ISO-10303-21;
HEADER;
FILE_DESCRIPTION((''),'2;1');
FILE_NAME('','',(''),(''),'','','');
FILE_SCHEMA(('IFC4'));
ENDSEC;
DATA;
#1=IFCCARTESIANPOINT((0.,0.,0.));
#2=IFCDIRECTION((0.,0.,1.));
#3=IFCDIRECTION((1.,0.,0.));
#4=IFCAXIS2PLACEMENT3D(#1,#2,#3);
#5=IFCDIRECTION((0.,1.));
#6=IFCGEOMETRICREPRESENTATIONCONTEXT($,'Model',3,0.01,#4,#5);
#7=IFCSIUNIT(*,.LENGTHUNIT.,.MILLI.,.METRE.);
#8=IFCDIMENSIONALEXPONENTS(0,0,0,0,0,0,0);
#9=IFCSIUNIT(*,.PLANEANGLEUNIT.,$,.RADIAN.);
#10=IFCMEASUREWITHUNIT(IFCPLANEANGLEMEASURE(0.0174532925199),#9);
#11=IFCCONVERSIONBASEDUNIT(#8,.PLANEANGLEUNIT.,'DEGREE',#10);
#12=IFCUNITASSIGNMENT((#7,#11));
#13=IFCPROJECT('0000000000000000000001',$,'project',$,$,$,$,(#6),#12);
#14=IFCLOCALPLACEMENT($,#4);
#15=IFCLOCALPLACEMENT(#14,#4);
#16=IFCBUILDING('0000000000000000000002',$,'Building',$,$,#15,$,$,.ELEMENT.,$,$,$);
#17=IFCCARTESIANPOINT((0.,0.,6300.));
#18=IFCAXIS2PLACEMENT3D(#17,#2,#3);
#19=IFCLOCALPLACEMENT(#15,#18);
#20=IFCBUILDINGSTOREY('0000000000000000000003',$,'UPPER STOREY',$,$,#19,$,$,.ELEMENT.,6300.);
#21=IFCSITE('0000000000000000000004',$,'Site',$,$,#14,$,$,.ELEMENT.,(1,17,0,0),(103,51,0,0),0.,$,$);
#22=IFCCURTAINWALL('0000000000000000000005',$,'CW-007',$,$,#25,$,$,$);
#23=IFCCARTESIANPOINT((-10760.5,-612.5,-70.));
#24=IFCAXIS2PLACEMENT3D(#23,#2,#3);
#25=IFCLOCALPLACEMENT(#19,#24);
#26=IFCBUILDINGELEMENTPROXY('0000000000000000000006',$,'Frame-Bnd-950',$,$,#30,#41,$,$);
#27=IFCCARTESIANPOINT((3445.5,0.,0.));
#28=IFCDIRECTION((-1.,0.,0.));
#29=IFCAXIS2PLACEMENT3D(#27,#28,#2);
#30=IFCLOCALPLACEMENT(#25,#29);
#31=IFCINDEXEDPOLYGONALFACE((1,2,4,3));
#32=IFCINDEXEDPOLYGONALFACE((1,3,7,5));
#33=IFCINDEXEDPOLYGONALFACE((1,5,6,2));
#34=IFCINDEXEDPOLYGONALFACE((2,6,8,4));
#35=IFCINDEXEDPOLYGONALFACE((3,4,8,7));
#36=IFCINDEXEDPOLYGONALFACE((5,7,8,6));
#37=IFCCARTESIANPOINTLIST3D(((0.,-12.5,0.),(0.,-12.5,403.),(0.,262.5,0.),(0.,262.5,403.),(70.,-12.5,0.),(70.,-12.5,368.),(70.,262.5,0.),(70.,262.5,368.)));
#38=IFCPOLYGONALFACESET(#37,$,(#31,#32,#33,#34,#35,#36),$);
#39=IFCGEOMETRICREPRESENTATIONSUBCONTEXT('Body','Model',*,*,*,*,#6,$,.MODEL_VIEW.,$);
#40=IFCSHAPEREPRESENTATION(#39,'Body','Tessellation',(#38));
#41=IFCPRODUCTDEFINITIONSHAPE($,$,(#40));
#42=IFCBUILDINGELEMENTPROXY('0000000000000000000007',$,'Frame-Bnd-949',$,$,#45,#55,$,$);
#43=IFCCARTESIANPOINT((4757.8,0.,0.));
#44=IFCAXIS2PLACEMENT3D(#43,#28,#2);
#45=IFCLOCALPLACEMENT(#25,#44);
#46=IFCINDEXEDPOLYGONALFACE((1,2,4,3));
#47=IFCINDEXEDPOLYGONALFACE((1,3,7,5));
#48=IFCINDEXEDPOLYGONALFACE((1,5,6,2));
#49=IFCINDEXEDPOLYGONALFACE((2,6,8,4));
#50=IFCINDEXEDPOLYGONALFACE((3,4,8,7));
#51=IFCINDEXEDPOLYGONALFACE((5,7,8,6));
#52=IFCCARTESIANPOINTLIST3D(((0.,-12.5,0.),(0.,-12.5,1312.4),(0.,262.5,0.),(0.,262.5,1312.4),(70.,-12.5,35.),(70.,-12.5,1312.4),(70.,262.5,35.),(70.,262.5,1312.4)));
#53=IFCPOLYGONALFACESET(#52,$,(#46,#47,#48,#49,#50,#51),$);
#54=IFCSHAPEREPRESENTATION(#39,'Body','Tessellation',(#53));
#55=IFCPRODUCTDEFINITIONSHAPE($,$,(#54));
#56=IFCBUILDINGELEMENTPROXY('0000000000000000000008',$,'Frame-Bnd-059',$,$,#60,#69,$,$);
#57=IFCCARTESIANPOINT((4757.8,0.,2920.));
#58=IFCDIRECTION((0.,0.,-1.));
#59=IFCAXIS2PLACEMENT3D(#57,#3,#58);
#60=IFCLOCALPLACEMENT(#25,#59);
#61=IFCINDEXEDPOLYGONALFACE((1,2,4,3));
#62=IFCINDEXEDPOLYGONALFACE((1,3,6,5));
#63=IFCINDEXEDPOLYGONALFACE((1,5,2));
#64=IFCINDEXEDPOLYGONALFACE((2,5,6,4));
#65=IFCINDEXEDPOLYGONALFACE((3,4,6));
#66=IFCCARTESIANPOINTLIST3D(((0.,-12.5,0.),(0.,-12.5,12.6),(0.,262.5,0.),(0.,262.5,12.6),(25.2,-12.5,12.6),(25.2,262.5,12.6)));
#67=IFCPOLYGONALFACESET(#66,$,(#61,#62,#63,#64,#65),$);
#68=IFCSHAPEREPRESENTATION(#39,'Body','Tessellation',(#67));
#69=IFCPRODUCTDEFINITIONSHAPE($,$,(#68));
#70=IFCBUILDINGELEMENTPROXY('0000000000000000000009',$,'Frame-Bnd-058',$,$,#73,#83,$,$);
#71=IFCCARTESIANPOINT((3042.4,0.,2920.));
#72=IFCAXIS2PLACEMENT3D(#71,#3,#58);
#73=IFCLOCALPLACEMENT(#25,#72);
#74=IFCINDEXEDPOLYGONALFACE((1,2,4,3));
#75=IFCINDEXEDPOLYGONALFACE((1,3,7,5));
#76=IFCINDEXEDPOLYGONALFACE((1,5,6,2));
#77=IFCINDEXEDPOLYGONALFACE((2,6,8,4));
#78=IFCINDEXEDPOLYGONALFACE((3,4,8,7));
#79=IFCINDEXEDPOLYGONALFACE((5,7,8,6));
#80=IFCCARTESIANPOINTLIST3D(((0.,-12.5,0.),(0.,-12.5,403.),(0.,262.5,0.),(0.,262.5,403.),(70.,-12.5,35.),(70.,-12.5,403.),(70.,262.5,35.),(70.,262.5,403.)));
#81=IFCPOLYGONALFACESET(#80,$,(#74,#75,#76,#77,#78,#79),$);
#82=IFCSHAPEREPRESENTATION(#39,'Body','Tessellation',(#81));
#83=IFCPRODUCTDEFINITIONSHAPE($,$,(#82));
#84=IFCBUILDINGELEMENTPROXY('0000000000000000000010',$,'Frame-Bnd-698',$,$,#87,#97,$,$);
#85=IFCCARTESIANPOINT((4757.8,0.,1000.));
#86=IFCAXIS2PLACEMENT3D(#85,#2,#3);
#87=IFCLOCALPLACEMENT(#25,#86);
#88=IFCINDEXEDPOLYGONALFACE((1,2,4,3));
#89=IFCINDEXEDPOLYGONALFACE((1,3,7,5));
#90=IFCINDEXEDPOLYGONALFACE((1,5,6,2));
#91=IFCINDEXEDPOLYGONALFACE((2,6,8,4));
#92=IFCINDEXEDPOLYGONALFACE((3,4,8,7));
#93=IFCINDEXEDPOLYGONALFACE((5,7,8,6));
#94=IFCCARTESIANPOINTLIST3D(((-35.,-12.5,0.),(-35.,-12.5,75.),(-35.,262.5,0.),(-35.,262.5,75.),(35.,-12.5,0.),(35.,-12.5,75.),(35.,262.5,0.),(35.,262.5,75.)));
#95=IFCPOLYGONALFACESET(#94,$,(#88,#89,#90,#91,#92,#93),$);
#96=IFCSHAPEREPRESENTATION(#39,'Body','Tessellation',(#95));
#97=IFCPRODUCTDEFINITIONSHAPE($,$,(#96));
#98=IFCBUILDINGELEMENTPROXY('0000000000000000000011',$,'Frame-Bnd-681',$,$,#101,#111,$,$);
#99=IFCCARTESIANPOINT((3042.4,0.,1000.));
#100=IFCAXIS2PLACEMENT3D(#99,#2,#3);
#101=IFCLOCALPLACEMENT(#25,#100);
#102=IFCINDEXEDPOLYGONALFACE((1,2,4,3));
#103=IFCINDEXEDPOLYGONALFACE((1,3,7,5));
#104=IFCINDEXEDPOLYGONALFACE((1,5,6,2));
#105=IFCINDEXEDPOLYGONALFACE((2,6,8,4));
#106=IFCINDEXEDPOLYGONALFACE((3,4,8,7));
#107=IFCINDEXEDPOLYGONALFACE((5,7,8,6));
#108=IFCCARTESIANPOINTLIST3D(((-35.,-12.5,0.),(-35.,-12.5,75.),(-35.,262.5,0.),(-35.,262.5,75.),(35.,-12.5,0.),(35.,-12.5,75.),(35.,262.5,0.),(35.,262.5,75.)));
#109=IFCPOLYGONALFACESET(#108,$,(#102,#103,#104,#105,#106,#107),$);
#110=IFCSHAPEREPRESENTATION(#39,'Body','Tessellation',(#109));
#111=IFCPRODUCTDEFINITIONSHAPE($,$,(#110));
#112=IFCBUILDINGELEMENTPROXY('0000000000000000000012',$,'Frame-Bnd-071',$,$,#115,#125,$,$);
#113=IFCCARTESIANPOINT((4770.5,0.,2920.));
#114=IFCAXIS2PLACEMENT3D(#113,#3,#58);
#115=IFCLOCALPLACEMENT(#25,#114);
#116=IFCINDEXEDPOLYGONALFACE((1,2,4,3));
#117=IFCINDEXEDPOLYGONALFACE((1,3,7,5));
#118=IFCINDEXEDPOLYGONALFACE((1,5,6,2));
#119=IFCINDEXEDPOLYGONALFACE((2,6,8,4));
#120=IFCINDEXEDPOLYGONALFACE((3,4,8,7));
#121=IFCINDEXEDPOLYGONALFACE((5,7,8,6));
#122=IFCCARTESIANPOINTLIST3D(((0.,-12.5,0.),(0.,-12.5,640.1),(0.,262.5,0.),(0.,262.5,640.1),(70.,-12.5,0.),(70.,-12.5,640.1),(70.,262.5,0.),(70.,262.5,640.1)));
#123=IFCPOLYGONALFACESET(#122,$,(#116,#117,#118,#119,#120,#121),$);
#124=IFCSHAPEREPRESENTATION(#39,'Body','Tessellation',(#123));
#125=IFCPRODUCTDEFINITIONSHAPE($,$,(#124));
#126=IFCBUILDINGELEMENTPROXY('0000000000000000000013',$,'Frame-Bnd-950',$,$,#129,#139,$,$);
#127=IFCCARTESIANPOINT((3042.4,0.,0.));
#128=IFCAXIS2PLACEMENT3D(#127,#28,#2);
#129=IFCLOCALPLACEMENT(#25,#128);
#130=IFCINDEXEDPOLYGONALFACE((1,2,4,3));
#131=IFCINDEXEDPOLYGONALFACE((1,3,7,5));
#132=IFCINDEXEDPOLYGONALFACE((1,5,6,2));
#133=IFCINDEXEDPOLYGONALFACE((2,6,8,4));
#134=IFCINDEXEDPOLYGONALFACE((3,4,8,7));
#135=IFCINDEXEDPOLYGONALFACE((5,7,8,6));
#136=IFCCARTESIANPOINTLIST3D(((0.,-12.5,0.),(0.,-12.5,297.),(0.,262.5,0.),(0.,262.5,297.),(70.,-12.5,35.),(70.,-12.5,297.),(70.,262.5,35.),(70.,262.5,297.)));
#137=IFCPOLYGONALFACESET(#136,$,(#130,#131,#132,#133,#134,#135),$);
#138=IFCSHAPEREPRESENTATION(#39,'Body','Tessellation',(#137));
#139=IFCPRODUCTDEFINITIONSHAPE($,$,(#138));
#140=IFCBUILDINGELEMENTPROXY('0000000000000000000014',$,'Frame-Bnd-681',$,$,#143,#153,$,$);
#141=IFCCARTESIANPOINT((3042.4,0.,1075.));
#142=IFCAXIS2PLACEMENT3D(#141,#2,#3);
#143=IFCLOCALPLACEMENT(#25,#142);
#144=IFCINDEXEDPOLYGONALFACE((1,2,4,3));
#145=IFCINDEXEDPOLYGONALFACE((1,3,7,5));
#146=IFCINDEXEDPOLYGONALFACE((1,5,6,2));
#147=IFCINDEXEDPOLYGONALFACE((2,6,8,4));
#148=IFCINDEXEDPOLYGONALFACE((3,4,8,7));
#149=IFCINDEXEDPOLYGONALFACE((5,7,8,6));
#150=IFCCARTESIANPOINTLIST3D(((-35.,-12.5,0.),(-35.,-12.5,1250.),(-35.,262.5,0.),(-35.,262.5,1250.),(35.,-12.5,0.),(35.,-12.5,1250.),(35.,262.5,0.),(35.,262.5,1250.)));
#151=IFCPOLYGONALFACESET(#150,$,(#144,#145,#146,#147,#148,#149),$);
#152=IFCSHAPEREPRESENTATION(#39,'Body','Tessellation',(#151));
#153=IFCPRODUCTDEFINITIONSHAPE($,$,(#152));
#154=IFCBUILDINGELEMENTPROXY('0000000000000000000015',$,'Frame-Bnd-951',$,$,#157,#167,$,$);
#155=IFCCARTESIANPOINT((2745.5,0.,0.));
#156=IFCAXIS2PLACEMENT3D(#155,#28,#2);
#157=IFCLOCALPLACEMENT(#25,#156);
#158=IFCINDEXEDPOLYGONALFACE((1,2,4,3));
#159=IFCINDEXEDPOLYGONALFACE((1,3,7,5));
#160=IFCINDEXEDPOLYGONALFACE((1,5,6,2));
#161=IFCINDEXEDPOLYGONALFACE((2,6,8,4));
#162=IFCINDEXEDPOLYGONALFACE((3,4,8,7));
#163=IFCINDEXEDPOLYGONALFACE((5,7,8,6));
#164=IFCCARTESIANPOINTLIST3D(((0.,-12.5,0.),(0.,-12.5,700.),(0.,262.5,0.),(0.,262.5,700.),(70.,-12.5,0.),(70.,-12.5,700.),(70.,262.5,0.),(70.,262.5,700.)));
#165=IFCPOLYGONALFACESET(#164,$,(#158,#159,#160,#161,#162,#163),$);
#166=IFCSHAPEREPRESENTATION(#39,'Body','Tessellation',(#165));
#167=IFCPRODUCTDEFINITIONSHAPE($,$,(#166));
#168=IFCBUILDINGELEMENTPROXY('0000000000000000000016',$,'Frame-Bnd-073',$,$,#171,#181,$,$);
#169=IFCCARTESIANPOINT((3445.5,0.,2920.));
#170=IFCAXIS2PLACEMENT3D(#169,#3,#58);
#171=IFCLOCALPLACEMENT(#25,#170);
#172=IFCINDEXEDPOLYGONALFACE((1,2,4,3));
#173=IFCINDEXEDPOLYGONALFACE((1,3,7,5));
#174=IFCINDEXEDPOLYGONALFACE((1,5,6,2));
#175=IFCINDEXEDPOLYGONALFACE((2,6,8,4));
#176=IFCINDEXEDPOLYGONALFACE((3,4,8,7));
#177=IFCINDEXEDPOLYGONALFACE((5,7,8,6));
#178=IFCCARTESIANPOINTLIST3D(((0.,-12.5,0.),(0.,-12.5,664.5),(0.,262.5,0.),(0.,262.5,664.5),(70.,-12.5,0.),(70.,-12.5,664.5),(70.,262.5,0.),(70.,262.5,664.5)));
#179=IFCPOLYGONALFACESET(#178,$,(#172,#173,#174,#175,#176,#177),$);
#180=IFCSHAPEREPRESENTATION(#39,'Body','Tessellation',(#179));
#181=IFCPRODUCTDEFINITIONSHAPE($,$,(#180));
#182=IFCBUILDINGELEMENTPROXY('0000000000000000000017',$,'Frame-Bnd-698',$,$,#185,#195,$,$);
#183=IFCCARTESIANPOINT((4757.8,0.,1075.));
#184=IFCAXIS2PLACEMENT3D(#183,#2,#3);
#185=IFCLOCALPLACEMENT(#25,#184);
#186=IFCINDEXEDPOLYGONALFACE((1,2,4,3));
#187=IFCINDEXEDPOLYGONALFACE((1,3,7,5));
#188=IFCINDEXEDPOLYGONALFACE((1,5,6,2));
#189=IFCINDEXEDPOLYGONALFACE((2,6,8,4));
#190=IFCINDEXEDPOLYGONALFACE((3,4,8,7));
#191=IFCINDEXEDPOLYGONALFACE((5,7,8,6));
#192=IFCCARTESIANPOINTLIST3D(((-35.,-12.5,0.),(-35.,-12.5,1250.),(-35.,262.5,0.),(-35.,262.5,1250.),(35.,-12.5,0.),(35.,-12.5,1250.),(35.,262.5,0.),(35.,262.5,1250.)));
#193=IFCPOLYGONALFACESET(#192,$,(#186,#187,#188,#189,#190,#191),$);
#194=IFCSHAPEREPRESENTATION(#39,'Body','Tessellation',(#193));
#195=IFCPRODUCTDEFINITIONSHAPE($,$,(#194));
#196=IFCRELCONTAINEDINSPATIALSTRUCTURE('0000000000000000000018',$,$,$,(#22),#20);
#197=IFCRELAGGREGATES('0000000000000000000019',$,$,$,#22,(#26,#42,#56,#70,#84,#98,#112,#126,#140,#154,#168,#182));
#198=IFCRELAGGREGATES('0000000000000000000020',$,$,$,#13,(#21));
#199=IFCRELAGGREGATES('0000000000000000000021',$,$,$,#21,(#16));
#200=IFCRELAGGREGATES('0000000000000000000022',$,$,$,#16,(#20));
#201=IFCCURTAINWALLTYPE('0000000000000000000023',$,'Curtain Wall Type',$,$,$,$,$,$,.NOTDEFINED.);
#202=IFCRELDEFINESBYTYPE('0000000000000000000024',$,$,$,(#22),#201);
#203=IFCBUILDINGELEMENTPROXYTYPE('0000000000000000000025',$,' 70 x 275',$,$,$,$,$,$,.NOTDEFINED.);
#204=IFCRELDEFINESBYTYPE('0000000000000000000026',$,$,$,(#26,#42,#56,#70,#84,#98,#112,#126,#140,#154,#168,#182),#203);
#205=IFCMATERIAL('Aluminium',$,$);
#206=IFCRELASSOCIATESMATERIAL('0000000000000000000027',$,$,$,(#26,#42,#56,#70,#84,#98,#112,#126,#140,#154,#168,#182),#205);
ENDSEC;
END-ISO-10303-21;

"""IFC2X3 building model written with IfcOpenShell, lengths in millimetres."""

from ifc_helpers import new_model, entity, si_unit, converted_unit, direction, frame, origin_with_axes, place, context, subcontext, project, spatial, polyline, outline, extrude, clip, halfspace, material, type_object, element, aggregate, save


model = new_model("IFC2X3")

# Units and contexts
model_context = context("Model", 3, precision=0.01, world=origin_with_axes(), true_north=direction((0.0, 1.0)))
body_context = subcontext(model_context, "Body", "Model", "MODEL_VIEW")
ifc_project = project(units=[si_unit("LENGTHUNIT", "METRE", prefix="MILLI"), converted_unit("PLANEANGLEUNIT", "DEGREE", entity("IfcPlaneAngleMeasure", 0.0174532925199), si_unit("PLANEANGLEUNIT", "RADIAN"), dimensions=[0, 0, 0, 0, 0, 0, 0])], contexts=[model_context])

# Site, building, storey
site_placement = place(None, origin_with_axes())
site = spatial("IfcSite", under=ifc_project, at=site_placement, Name="Site", CompositionType="ELEMENT", RefLatitude=(1, 17, 0, 0), RefLongitude=(103, 51, 0, 0), RefElevation=0.0)
building_placement = place(site_placement, origin_with_axes())
building = spatial("IfcBuilding", under=site, at=building_placement, Name="Building", CompositionType="ELEMENT")
storey_placement = place(building_placement, frame((0.0, 0.0, 6300.0), z_axis=(0.0, 0.0, 1.0), x_axis=(1.0, 0.0, 0.0)))
storey = spatial("IfcBuildingStorey", under=building, at=storey_placement, Name="UPPER STOREY", CompositionType="ELEMENT", Elevation=6300.0)

# Curtain wall, building element proxies
curtain_wall_type = type_object("IfcCurtainWallType", Name="Curtain Wall Type", PredefinedType="NOTDEFINED")
curtain_wall_placement = place(storey_placement, frame((-10760.5, -612.5, -70.0), z_axis=(0.0, 0.0, 1.0), x_axis=(1.0, 0.0, 0.0)))
curtain_wall = element("IfcCurtainWall", 1, at=curtain_wall_placement, inside=storey, type_object=curtain_wall_type, Name="CW-007")
ifc_material_1 = material(Name="Aluminium")
building_element_proxy_type_1 = type_object("IfcBuildingElementProxyType", Name=" 70 x 275", PredefinedType="NOTDEFINED")
proxy_1_placement = place(curtain_wall_placement, frame((3445.5, 0.0, 0.0), z_axis=(-1.0, 0.0, 0.0), x_axis=(0.0, 0.0, 1.0)))
proxy_1 = element("IfcBuildingElementProxy", 2, at=proxy_1_placement, type_object=building_element_proxy_type_1, material=ifc_material_1, Name="Frame-Bnd-950", context=body_context, shape_type="Clipping", body=[
    clip(extrude(outline(polyline([(262.5, -70.0), (262.5, 0.0), (-12.5, 0.0), (-12.5, -70.0), (262.5, -70.0)])), frame((0.0, 0.0, 0.0), z_axis=(0.0, 0.0, 1.0), x_axis=(0.0, 1.0, 0.0)), (0.0, 0.0, 1.0), 403.0), halfspace(frame((161.2, 0.0, 322.4), z_axis=(-0.447214, 0.0, -0.894427), x_axis=(0.0, 1.0, 0.0)), True)),
])
proxy_2_placement = place(curtain_wall_placement, frame((4757.8, 0.0, 0.0), z_axis=(-1.0, 0.0, 0.0), x_axis=(0.0, 0.0, 1.0)))
proxy_2 = element("IfcBuildingElementProxy", 3, at=proxy_2_placement, type_object=building_element_proxy_type_1, material=ifc_material_1, Name="Frame-Bnd-949", context=body_context, shape_type="Clipping", body=[
    clip(extrude(outline(polyline([(262.5, -70.0), (262.5, 0.0), (-12.5, 0.0), (-12.5, -70.0), (262.5, -70.0)])), frame((0.0, 0.0, 0.0), z_axis=(0.0, 0.0, 1.0), x_axis=(0.0, 1.0, 0.0)), (0.0, 0.0, 1.0), 1312.4), halfspace(frame((0.0, 0.0, 0.0), z_axis=(-0.447214, 0.0, 0.894427), x_axis=(0.0, -1.0, 0.0)), True)),
])
proxy_3_placement = place(curtain_wall_placement, frame((4757.8, 0.0, 2920.0), z_axis=(1.0, 0.0, 0.0), x_axis=(0.0, 0.0, -1.0)))
proxy_3 = element("IfcBuildingElementProxy", 4, at=proxy_3_placement, type_object=building_element_proxy_type_1, material=ifc_material_1, Name="Frame-Bnd-059", context=body_context, shape_type="Clipping", body=[
    clip(extrude(outline(polyline([(12.5, 25.2), (-262.5, 25.2), (-262.5, 0.0), (12.5, 0.0), (12.5, 25.2)])), frame((0.0, 0.0, 0.0), z_axis=(0.0, 0.0, 1.0), x_axis=(0.0, -1.0, 0.0)), (0.0, 0.0, 1.0), 12.6), halfspace(frame((0.0, 0.0, 0.0), z_axis=(-0.447214, 0.0, 0.894427), x_axis=(0.0, -1.0, 0.0)), True)),
])
proxy_4_placement = place(curtain_wall_placement, frame((3042.4, 0.0, 2920.0), z_axis=(1.0, 0.0, 0.0), x_axis=(0.0, 0.0, -1.0)))
proxy_4 = element("IfcBuildingElementProxy", 5, at=proxy_4_placement, type_object=building_element_proxy_type_1, material=ifc_material_1, Name="Frame-Bnd-058", context=body_context, shape_type="Clipping", body=[
    clip(extrude(outline(polyline([(-262.5, 70.0), (-262.5, 0.0), (12.5, 0.0), (12.5, 70.0), (-262.5, 70.0)])), frame((0.0, 0.0, 0.0), z_axis=(0.0, 0.0, 1.0), x_axis=(0.0, -1.0, 0.0)), (0.0, 0.0, 1.0), 403.0), halfspace(frame((0.0, 0.0, 0.0), z_axis=(-0.447214, 0.0, 0.894427), x_axis=(0.0, -1.0, 0.0)), True)),
])
proxy_5_placement = place(curtain_wall_placement, frame((4757.8, 0.0, 1000.0), z_axis=(0.0, 0.0, 1.0), x_axis=(1.0, 0.0, 0.0)))
proxy_5 = element("IfcBuildingElementProxy", 6, at=proxy_5_placement, type_object=building_element_proxy_type_1, material=ifc_material_1, Name="Frame-Bnd-698", context=body_context, shape_type="SweptSolid", body=[
    extrude(outline(polyline([(35.0, 262.5), (-35.0, 262.5), (-35.0, -12.5), (35.0, -12.5), (35.0, 262.5)])), frame((0.0, 0.0, 0.0), z_axis=(0.0, 0.0, 1.0), x_axis=(1.0, 0.0, 0.0)), (0.0, 0.0, 1.0), 75.0),
])
proxy_6_placement = place(curtain_wall_placement, frame((3042.4, 0.0, 1000.0), z_axis=(0.0, 0.0, 1.0), x_axis=(1.0, 0.0, 0.0)))
proxy_6 = element("IfcBuildingElementProxy", 7, at=proxy_6_placement, type_object=building_element_proxy_type_1, material=ifc_material_1, Name="Frame-Bnd-681", context=body_context, shape_type="SweptSolid", body=[
    extrude(outline(polyline([(35.0, 262.5), (-35.0, 262.5), (-35.0, -12.5), (35.0, -12.5), (35.0, 262.5)])), frame((0.0, 0.0, 0.0), z_axis=(0.0, 0.0, 1.0), x_axis=(1.0, 0.0, 0.0)), (0.0, 0.0, 1.0), 75.0),
])
proxy_7_placement = place(curtain_wall_placement, frame((4770.5, 0.0, 2920.0), z_axis=(1.0, 0.0, 0.0), x_axis=(0.0, 0.0, -1.0)))
proxy_7 = element("IfcBuildingElementProxy", 8, at=proxy_7_placement, type_object=building_element_proxy_type_1, material=ifc_material_1, Name="Frame-Bnd-071", context=body_context, shape_type="SweptSolid", body=[
    extrude(outline(polyline([(-262.5, 70.0), (-262.5, 0.0), (12.5, 0.0), (12.5, 70.0), (-262.5, 70.0)])), frame((0.0, 0.0, 0.0), z_axis=(0.0, 0.0, 1.0), x_axis=(0.0, -1.0, 0.0)), (0.0, 0.0, 1.0), 640.1),
])
proxy_8_placement = place(curtain_wall_placement, frame((3042.4, 0.0, 0.0), z_axis=(-1.0, 0.0, 0.0), x_axis=(0.0, 0.0, 1.0)))
proxy_8 = element("IfcBuildingElementProxy", 9, at=proxy_8_placement, type_object=building_element_proxy_type_1, material=ifc_material_1, Name="Frame-Bnd-950", context=body_context, shape_type="Clipping", body=[
    clip(extrude(outline(polyline([(262.5, -70.0), (262.5, 0.0), (-12.5, 0.0), (-12.5, -70.0), (262.5, -70.0)])), frame((0.0, 0.0, 0.0), z_axis=(0.0, 0.0, 1.0), x_axis=(0.0, 1.0, 0.0)), (0.0, 0.0, 1.0), 297.0), halfspace(frame((0.0, 0.0, 0.0), z_axis=(-0.447214, 0.0, 0.894427), x_axis=(0.0, -1.0, 0.0)), True)),
])
proxy_9_placement = place(curtain_wall_placement, frame((3042.4, 0.0, 1075.0), z_axis=(0.0, 0.0, 1.0), x_axis=(1.0, 0.0, 0.0)))
proxy_9 = element("IfcBuildingElementProxy", 10, at=proxy_9_placement, type_object=building_element_proxy_type_1, material=ifc_material_1, Name="Frame-Bnd-681", context=body_context, shape_type="SweptSolid", body=[
    extrude(outline(polyline([(35.0, 262.5), (-35.0, 262.5), (-35.0, -12.5), (35.0, -12.5), (35.0, 262.5)])), frame((0.0, 0.0, 0.0), z_axis=(0.0, 0.0, 1.0), x_axis=(1.0, 0.0, 0.0)), (0.0, 0.0, 1.0), 1250.0),
])
proxy_10_placement = place(curtain_wall_placement, frame((2745.5, 0.0, 0.0), z_axis=(-1.0, 0.0, 0.0), x_axis=(0.0, 0.0, 1.0)))
proxy_10 = element("IfcBuildingElementProxy", 11, at=proxy_10_placement, type_object=building_element_proxy_type_1, material=ifc_material_1, Name="Frame-Bnd-951", context=body_context, shape_type="SweptSolid", body=[
    extrude(outline(polyline([(262.5, -70.0), (262.5, 0.0), (-12.5, 0.0), (-12.5, -70.0), (262.5, -70.0)])), frame((0.0, 0.0, 0.0), z_axis=(0.0, 0.0, 1.0), x_axis=(0.0, 1.0, 0.0)), (0.0, 0.0, 1.0), 700.0),
])
proxy_11_placement = place(curtain_wall_placement, frame((3445.5, 0.0, 2920.0), z_axis=(1.0, 0.0, 0.0), x_axis=(0.0, 0.0, -1.0)))
proxy_11 = element("IfcBuildingElementProxy", 12, at=proxy_11_placement, type_object=building_element_proxy_type_1, material=ifc_material_1, Name="Frame-Bnd-073", context=body_context, shape_type="SweptSolid", body=[
    extrude(outline(polyline([(-262.5, 70.0), (-262.5, 0.0), (12.5, 0.0), (12.5, 70.0), (-262.5, 70.0)])), frame((0.0, 0.0, 0.0), z_axis=(0.0, 0.0, 1.0), x_axis=(0.0, -1.0, 0.0)), (0.0, 0.0, 1.0), 664.5),
])
proxy_12_placement = place(curtain_wall_placement, frame((4757.8, 0.0, 1075.0), z_axis=(0.0, 0.0, 1.0), x_axis=(1.0, 0.0, 0.0)))
proxy_12 = element("IfcBuildingElementProxy", 13, at=proxy_12_placement, type_object=building_element_proxy_type_1, material=ifc_material_1, Name="Frame-Bnd-698", context=body_context, shape_type="SweptSolid", body=[
    extrude(outline(polyline([(35.0, 262.5), (-35.0, 262.5), (-35.0, -12.5), (35.0, -12.5), (35.0, 262.5)])), frame((0.0, 0.0, 0.0), z_axis=(0.0, 0.0, 1.0), x_axis=(1.0, 0.0, 0.0)), (0.0, 0.0, 1.0), 1250.0),
])
aggregate(curtain_wall, [proxy_1, proxy_2, proxy_3, proxy_4, proxy_5, proxy_6, proxy_7, proxy_8, proxy_9, proxy_10, proxy_11, proxy_12])

save(model, "model.ifc")
